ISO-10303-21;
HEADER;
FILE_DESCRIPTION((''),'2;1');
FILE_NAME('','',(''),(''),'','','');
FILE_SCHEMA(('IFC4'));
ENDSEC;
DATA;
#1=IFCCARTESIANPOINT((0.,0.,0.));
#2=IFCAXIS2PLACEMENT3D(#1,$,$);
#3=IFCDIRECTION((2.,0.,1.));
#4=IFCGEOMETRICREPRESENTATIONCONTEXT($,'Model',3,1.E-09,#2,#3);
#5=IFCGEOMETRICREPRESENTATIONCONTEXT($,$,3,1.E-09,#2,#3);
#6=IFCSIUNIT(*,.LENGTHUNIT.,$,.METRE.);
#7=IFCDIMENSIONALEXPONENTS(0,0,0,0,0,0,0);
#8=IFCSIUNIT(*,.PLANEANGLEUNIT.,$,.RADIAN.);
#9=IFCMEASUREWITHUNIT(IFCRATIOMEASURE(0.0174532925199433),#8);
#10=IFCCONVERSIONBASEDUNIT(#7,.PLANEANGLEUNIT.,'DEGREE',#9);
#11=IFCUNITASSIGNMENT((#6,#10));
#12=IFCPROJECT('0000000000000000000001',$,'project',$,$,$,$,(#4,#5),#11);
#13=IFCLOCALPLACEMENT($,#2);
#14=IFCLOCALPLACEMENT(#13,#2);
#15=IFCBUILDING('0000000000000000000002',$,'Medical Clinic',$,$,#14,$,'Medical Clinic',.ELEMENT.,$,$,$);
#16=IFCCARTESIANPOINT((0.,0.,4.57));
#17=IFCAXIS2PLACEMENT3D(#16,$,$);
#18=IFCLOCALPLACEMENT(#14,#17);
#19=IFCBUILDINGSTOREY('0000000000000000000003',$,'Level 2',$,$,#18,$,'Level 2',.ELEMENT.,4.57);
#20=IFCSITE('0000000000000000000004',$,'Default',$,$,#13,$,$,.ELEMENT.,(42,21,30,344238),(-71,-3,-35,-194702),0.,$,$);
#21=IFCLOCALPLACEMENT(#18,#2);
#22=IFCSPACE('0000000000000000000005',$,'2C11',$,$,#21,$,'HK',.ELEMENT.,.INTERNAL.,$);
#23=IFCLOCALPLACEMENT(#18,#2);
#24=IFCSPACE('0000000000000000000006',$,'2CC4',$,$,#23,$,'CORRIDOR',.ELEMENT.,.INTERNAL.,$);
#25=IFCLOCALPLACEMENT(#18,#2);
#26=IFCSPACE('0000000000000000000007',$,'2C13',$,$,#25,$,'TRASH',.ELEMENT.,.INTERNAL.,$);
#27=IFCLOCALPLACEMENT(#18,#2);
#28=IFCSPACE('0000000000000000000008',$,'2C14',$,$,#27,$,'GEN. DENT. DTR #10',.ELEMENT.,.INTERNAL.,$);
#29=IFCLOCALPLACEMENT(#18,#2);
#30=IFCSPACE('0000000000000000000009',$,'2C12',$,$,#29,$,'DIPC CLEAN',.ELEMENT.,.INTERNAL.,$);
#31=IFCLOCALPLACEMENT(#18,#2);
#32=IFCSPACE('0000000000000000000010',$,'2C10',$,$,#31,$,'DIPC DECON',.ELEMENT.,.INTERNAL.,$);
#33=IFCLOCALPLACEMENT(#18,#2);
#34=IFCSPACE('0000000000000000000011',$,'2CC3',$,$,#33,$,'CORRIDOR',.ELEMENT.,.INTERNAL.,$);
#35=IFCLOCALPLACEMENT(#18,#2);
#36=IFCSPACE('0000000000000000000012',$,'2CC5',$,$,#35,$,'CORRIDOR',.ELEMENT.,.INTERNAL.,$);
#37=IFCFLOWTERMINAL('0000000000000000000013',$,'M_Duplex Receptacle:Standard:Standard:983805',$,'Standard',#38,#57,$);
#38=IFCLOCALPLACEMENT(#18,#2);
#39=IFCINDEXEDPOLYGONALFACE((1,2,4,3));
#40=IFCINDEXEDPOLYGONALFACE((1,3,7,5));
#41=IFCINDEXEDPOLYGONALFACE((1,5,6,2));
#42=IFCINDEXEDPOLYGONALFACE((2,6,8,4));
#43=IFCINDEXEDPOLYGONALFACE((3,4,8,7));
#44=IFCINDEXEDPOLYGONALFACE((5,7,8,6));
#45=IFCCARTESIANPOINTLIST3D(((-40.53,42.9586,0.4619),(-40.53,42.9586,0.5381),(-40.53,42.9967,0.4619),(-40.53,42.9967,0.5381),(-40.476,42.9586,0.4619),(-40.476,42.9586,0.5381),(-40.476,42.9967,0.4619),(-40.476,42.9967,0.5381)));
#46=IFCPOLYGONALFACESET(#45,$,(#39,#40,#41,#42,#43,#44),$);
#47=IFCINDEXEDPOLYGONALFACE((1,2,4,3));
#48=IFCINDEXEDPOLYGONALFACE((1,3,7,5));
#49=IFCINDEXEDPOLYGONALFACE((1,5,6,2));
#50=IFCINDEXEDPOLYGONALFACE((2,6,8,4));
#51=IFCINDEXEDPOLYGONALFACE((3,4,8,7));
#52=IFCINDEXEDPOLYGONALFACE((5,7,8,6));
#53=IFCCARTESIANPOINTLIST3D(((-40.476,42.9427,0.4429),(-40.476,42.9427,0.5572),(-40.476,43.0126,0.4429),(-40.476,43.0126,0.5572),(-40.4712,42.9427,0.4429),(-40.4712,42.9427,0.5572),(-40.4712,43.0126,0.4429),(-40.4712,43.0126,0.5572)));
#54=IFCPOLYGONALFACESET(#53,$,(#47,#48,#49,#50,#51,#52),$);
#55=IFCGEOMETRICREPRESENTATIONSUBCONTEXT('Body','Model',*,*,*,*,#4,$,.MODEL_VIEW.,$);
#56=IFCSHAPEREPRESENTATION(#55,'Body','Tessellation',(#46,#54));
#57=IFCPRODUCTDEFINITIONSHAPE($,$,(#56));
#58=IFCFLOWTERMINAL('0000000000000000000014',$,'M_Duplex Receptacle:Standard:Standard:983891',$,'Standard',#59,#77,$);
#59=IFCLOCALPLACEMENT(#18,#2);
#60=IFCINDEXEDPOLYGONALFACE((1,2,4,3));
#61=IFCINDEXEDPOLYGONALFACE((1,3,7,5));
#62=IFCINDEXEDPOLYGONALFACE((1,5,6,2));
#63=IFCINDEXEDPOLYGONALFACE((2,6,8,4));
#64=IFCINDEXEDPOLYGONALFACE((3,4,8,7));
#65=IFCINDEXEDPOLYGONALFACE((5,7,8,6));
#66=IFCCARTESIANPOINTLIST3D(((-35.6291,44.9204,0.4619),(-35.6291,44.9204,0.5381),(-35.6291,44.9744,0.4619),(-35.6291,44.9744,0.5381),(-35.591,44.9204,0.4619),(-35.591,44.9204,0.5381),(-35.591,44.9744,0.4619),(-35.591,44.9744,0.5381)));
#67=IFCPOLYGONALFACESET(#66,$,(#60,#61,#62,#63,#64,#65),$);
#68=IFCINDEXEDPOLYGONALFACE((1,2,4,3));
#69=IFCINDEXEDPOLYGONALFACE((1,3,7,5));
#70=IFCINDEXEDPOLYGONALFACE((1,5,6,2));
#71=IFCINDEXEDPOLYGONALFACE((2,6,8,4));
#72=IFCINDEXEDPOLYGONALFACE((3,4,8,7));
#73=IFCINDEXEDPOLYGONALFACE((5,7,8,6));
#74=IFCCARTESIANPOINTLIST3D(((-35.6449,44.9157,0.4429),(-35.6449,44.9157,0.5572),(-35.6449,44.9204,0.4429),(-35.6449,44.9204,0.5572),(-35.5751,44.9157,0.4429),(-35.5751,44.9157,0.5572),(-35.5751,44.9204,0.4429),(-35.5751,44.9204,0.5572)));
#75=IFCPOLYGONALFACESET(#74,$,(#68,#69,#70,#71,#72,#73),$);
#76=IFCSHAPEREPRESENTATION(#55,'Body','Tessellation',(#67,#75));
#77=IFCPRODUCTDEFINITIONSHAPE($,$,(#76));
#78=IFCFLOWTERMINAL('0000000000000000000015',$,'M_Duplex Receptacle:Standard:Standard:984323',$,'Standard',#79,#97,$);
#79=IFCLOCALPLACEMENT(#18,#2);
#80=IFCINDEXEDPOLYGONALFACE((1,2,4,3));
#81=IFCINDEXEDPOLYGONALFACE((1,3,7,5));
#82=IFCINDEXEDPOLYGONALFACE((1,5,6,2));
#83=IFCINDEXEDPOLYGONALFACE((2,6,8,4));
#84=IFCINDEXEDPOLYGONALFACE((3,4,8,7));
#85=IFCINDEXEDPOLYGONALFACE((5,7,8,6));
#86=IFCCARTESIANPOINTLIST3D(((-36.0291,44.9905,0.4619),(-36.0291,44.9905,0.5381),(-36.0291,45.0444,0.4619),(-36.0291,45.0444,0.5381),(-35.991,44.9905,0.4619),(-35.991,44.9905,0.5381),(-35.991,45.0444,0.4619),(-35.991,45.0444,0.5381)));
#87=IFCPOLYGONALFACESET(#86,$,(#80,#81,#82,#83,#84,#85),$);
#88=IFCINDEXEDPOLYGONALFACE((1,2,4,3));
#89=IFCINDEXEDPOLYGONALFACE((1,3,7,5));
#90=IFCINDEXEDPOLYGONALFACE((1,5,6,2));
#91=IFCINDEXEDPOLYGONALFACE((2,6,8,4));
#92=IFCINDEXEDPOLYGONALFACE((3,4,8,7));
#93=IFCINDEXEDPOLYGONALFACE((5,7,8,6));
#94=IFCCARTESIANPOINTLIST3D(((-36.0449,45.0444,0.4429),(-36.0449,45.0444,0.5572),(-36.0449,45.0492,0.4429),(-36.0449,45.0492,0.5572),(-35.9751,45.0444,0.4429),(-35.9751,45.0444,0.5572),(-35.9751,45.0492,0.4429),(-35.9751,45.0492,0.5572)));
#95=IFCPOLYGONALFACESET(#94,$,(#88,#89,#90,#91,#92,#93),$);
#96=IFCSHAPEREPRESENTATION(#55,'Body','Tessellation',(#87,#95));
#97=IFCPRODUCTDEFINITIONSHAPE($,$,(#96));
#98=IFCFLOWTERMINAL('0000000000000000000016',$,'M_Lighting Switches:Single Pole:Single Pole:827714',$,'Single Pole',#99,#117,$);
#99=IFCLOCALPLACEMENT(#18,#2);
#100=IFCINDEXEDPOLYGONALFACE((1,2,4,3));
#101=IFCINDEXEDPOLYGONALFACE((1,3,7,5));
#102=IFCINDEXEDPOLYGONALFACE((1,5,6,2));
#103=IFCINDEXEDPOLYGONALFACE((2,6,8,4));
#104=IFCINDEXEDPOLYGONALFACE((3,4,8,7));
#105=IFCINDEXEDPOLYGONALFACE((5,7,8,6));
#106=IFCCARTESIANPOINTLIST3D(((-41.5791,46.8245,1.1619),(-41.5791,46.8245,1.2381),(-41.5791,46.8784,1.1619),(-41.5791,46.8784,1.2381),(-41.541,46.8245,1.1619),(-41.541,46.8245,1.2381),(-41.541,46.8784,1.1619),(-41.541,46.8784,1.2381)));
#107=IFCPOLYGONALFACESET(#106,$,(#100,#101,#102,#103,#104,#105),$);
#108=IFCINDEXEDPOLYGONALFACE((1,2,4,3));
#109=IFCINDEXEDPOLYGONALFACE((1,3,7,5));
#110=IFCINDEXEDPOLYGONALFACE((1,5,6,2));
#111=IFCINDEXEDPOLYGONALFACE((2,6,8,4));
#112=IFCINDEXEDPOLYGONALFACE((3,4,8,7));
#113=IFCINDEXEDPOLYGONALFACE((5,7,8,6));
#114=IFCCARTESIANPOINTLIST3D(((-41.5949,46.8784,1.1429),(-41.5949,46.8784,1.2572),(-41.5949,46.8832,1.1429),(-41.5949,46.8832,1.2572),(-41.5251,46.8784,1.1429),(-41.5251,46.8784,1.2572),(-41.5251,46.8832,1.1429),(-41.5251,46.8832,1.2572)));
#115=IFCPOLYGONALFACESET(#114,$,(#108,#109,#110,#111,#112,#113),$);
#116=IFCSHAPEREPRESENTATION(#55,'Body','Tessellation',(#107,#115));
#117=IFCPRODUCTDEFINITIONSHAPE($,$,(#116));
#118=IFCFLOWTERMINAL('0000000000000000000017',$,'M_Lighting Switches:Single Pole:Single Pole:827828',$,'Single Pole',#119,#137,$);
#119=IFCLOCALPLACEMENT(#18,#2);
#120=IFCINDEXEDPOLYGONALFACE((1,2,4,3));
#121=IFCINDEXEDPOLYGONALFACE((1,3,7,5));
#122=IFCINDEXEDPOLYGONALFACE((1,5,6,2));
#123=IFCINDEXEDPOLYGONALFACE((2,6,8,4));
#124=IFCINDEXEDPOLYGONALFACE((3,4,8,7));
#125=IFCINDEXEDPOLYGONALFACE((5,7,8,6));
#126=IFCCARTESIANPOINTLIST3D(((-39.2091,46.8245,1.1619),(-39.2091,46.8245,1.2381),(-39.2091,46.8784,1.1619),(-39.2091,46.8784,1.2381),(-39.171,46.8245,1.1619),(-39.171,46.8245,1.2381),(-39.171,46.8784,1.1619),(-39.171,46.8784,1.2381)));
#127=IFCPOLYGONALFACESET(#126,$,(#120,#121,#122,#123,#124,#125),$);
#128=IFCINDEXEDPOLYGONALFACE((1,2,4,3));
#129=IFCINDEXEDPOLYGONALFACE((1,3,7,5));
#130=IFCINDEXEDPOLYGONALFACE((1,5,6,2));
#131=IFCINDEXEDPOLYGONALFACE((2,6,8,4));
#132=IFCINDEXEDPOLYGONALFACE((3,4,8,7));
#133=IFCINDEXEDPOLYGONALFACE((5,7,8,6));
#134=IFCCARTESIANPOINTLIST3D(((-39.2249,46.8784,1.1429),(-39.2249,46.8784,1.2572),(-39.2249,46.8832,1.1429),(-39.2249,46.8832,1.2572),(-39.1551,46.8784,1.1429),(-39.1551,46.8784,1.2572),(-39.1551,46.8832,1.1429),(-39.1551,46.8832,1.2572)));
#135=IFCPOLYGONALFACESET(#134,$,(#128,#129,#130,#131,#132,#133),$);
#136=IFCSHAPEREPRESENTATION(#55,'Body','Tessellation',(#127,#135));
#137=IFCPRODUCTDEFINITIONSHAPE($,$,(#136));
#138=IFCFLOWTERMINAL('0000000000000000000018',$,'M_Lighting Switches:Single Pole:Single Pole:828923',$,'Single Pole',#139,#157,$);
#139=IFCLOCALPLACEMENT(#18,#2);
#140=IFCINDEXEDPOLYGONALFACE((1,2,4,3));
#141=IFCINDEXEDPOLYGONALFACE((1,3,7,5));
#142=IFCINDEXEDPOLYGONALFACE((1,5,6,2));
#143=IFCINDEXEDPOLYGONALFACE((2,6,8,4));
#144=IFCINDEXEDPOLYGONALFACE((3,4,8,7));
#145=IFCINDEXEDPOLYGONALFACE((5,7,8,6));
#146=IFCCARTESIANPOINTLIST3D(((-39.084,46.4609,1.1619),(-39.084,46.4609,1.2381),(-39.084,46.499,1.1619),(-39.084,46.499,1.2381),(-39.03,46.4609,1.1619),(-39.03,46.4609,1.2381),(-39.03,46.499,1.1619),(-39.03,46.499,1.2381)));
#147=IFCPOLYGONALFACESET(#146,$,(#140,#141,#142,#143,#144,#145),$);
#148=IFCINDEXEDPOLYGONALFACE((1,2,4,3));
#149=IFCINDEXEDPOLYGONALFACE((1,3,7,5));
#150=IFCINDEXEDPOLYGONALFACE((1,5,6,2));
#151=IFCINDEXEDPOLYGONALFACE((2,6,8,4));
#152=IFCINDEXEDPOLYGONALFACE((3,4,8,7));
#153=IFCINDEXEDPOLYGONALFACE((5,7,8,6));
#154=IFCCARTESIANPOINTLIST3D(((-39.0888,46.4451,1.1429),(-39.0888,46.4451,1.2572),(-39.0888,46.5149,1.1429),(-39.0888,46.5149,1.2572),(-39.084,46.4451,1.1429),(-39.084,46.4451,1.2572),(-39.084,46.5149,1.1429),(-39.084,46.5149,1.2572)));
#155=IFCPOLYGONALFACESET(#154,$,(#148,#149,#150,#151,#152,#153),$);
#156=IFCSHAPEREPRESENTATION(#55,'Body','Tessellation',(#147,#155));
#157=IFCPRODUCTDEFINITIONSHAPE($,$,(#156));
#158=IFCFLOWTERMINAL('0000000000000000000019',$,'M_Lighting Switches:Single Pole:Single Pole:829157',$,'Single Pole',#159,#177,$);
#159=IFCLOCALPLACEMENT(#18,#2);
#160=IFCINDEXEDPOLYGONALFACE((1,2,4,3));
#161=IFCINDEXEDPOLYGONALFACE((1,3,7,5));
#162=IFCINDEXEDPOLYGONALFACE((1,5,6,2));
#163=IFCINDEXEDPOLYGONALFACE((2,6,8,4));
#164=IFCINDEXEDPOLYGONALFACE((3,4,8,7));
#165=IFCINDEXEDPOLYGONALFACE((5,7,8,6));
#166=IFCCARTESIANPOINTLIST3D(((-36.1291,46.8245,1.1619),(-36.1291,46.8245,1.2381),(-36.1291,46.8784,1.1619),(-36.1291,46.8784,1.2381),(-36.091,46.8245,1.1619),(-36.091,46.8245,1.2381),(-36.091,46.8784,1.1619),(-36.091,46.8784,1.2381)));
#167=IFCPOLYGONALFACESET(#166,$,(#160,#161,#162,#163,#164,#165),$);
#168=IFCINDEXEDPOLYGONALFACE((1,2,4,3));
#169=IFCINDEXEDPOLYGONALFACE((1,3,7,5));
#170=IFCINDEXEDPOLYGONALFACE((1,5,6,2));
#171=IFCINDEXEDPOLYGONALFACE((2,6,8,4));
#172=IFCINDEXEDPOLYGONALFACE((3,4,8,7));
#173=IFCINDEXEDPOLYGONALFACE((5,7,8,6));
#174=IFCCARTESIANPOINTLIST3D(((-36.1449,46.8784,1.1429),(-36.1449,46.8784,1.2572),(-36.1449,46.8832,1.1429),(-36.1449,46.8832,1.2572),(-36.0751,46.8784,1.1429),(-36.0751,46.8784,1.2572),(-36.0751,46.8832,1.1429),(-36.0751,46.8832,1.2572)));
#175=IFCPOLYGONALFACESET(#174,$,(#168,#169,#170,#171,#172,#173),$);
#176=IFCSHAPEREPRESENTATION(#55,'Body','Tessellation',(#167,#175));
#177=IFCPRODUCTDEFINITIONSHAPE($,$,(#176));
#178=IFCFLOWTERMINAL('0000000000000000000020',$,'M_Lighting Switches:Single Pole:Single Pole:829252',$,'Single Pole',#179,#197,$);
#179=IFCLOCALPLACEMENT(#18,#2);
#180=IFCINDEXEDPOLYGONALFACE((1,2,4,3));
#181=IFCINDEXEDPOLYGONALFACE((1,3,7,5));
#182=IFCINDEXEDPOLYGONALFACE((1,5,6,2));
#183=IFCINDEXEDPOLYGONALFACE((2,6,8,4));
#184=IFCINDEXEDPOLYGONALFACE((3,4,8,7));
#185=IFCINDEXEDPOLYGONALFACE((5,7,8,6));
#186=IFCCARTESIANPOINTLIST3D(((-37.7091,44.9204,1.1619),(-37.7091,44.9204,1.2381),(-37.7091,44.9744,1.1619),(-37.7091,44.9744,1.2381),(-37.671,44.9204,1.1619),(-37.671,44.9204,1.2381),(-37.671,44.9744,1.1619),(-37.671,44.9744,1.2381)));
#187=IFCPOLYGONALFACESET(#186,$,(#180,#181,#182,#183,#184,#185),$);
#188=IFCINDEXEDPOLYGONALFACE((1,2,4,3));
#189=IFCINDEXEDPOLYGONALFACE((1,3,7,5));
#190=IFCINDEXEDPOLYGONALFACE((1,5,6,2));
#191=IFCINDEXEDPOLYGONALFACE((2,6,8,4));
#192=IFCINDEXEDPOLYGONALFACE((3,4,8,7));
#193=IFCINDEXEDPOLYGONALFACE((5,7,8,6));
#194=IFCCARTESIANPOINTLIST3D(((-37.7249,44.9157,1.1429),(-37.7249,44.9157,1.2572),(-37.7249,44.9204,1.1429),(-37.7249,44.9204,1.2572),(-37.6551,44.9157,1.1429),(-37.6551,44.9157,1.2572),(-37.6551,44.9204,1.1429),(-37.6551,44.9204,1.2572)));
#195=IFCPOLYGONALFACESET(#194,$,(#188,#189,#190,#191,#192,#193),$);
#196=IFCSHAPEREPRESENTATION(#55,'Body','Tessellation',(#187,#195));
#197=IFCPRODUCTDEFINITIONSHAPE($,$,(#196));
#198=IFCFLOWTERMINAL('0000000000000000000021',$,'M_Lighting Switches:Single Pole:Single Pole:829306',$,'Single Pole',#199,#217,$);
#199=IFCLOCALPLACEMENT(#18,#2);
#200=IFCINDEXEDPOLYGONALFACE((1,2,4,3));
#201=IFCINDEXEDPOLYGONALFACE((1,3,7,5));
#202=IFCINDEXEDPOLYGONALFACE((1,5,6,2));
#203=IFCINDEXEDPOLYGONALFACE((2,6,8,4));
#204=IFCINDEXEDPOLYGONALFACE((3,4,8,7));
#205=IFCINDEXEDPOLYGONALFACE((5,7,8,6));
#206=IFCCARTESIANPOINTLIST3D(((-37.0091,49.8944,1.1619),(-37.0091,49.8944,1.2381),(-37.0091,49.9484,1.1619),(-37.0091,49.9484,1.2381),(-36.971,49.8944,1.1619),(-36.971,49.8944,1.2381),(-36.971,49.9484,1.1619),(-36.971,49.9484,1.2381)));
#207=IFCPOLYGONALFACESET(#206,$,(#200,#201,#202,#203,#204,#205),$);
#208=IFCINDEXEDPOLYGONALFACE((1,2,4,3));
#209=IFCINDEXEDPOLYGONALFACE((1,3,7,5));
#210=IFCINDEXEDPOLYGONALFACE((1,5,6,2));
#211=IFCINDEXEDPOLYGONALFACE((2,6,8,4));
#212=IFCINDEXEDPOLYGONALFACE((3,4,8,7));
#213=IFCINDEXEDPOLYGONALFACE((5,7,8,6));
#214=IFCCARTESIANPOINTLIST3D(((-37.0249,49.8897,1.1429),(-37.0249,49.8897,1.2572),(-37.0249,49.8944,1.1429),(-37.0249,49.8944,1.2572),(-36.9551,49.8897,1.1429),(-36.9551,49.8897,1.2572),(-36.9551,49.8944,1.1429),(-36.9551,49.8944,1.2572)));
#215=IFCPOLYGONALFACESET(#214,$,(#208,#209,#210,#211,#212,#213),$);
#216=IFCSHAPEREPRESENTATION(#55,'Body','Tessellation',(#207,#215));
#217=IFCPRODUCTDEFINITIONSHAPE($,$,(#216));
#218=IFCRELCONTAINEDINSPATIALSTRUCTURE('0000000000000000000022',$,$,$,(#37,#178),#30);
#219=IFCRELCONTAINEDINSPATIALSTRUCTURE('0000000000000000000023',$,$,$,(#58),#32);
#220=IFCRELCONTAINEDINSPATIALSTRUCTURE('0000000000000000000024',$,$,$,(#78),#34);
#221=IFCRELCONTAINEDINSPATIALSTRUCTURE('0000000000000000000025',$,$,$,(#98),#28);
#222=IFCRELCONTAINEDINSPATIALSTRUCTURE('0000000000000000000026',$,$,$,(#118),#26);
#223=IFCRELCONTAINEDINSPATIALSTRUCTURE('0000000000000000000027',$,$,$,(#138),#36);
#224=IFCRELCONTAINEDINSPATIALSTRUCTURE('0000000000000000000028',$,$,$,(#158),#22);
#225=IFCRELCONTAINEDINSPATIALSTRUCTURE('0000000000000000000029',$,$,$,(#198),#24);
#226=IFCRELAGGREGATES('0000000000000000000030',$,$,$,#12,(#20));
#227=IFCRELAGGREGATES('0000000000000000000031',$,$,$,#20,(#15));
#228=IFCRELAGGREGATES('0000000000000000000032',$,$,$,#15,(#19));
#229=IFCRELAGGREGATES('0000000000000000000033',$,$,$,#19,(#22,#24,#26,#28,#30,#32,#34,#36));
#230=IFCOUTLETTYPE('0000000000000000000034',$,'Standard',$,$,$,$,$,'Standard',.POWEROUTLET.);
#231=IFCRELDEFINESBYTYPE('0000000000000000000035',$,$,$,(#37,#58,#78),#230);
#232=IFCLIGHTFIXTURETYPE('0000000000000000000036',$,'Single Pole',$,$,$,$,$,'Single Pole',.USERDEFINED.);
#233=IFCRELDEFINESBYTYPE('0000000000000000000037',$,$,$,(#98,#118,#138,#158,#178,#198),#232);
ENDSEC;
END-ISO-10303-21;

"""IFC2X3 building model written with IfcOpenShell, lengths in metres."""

from ifc_helpers import new_model, entity, si_unit, converted_unit, direction, frame, frame_2d, origin, origin_2d_with_axis, place, context, subcontext, project, spatial, rectangle, extrude, source, transform, mapped, type_object, type_shapes, element, save


model = new_model("IFC2X3")

# Units and contexts
model_context = context("Model", 3, precision=1e-09, world=origin(), true_north=direction((2.0, 0.0, 1.0)))
context_of_model = context(None, 3, precision=1e-09, world=origin(), true_north=direction((2.0, 0.0, 1.0)))
body_context = subcontext(model_context, "Body", "Model", "MODEL_VIEW")
ifc_project = project(units=[si_unit("LENGTHUNIT", "METRE"), converted_unit("PLANEANGLEUNIT", "DEGREE", entity("IfcRatioMeasure", 0.0174532925199433), si_unit("PLANEANGLEUNIT", "RADIAN"), dimensions=[0, 0, 0, 0, 0, 0, 0])], contexts=[model_context, context_of_model])

# Site, building, storey
site_placement = place(None, origin())
site = spatial("IfcSite", under=ifc_project, at=site_placement, Name="Default", CompositionType="ELEMENT", RefLatitude=(42, 21, 30, 344238), RefLongitude=(-71, -3, -35, -194702), RefElevation=0.0)
building_placement = place(site_placement, origin())
building = spatial("IfcBuilding", under=site, at=building_placement, Name="Medical Clinic", LongName="Medical Clinic", CompositionType="ELEMENT")
storey_placement = place(building_placement, frame((0.0, 0.0, 4.57)))
storey = spatial("IfcBuildingStorey", under=building, at=storey_placement, Name="Level 2", LongName="Level 2", CompositionType="ELEMENT", Elevation=4.57)

# Shared definitions
outlet_type = type_object("IfcOutletType", Name="Standard", ElementType="Standard", PredefinedType="POWEROUTLET")
shared_shape_1 = source(origin(), body_context, "Body", "SweptSolid", [
    extrude(rectangle(XDim=0.0381, YDim=0.0762, at=origin_2d_with_axis()), frame((0.0, 0.0, -0.054), z_axis=(0.0, 0.0, 1.0), x_axis=(-1.0, 0.0, 0.0)), (0.0, 0.0, 1.0), 0.054),
    extrude(rectangle(XDim=0.0698, YDim=0.1143, at=frame_2d((0.0, 0.0), x_axis=(1.0, 0.0))), frame((0.0, 0.0, 0.0), z_axis=(0.0, 0.0, 1.0), x_axis=(-1.0, 0.0, 0.0)), (0.0, 0.0, 1.0), 0.0048),
])
type_shapes(outlet_type, [shared_shape_1])

# Shared definitions
space_1_placement = place(storey_placement, origin())
space_1 = spatial("IfcSpace", under=storey, at=space_1_placement, Name="2C11", LongName="HK", CompositionType="ELEMENT", InteriorOrExteriorSpace="INTERNAL")

# Shared definitions
space_2_placement = place(storey_placement, origin())
space_2 = spatial("IfcSpace", under=storey, at=space_2_placement, Name="2CC4", LongName="CORRIDOR", CompositionType="ELEMENT", InteriorOrExteriorSpace="INTERNAL")

# Shared definitions
space_3_placement = place(storey_placement, origin())
space_3 = spatial("IfcSpace", under=storey, at=space_3_placement, Name="2C13", LongName="TRASH", CompositionType="ELEMENT", InteriorOrExteriorSpace="INTERNAL")

# Shared definitions
space_4_placement = place(storey_placement, origin())
space_4 = spatial("IfcSpace", under=storey, at=space_4_placement, Name="2C14", LongName="GEN. DENT. DTR #10", CompositionType="ELEMENT", InteriorOrExteriorSpace="INTERNAL")

# Shared definitions
space_5_placement = place(storey_placement, origin())
space_5 = spatial("IfcSpace", under=storey, at=space_5_placement, Name="2C12", LongName="DIPC CLEAN", CompositionType="ELEMENT", InteriorOrExteriorSpace="INTERNAL")

# Flow terminal
flow_terminal_1_placement = place(space_5_placement, frame((-40.476, 42.9776, 0.5), z_axis=(1.0, 0.0, 0.0), x_axis=(0.0, 1.0, 0.0)))
element("IfcFlowTerminal", 1, at=flow_terminal_1_placement, inside=space_5, type_object=outlet_type, Name="M_Duplex Receptacle:Standard:Standard:983805", ObjectType="Standard", context=body_context, shape_type="MappedRepresentation", body=[
    mapped(shared_shape_1, transform((0.0, 0.0, 0.0), scale=1.0)),
])

# Shared definitions
space_6_placement = place(storey_placement, origin())
space_6 = spatial("IfcSpace", under=storey, at=space_6_placement, Name="2C10", LongName="DIPC DECON", CompositionType="ELEMENT", InteriorOrExteriorSpace="INTERNAL")

# Flow terminal
flow_terminal_2_placement = place(space_6_placement, frame((-35.61, 44.9204, 0.5), z_axis=(0.0, -1.0, 0.0), x_axis=(1.0, 0.0, 0.0)))
element("IfcFlowTerminal", 2, at=flow_terminal_2_placement, inside=space_6, type_object=outlet_type, Name="M_Duplex Receptacle:Standard:Standard:983891", ObjectType="Standard", context=body_context, shape_type="MappedRepresentation", body=[
    mapped(shared_shape_1, transform((0.0, 0.0, 0.0), scale=1.0)),
])

# Shared definitions
space_7_placement = place(storey_placement, origin())
space_7 = spatial("IfcSpace", under=storey, at=space_7_placement, Name="2CC3", LongName="CORRIDOR", CompositionType="ELEMENT", InteriorOrExteriorSpace="INTERNAL")

# Flow terminals
flow_terminal_3_placement = place(space_7_placement, frame((-36.01, 45.0444, 0.5), z_axis=(0.0, 1.0, 0.0), x_axis=(-1.0, 0.0, 0.0)))
element("IfcFlowTerminal", 3, at=flow_terminal_3_placement, inside=space_7, type_object=outlet_type, Name="M_Duplex Receptacle:Standard:Standard:984323", ObjectType="Standard", context=body_context, shape_type="MappedRepresentation", body=[
    mapped(shared_shape_1, transform((0.0, 0.0, 0.0), scale=1.0)),
])
light_fixture_type_1 = type_object("IfcLightFixtureType", Name="Single Pole", ElementType="Single Pole", PredefinedType="USERDEFINED")
shared_shape_2 = source(origin(), body_context, "Body", "SweptSolid", [
    extrude(rectangle(XDim=0.0381, YDim=0.0762, at=origin_2d_with_axis()), frame((0.0, 0.0, -0.054), z_axis=(0.0, 0.0, 1.0), x_axis=(-1.0, 0.0, 0.0)), (0.0, 0.0, 1.0), 0.054),
    extrude(rectangle(XDim=0.0698, YDim=0.1143, at=frame_2d((0.0, 0.0), x_axis=(1.0, 0.0))), frame((0.0, 0.0, 0.0), z_axis=(0.0, 0.0, 1.0), x_axis=(-1.0, 0.0, 0.0)), (0.0, 0.0, 1.0), 0.0048),
])
type_shapes(light_fixture_type_1, [shared_shape_2])
flow_terminal_4_placement = place(space_4_placement, frame((-41.56, 46.8784, 1.2), z_axis=(0.0, 1.0, 0.0), x_axis=(-1.0, 0.0, 0.0)))
element("IfcFlowTerminal", 4, at=flow_terminal_4_placement, inside=space_4, type_object=light_fixture_type_1, Name="M_Lighting Switches:Single Pole:Single Pole:827714", ObjectType="Single Pole", context=body_context, shape_type="MappedRepresentation", body=[
    mapped(shared_shape_2, transform((0.0, 0.0, 0.0), scale=1.0)),
])
flow_terminal_5_placement = place(space_3_placement, frame((-39.19, 46.8784, 1.2), z_axis=(0.0, 1.0, 0.0), x_axis=(-1.0, 0.0, 0.0)))
element("IfcFlowTerminal", 5, at=flow_terminal_5_placement, inside=space_3, type_object=light_fixture_type_1, Name="M_Lighting Switches:Single Pole:Single Pole:827828", ObjectType="Single Pole", context=body_context, shape_type="MappedRepresentation", body=[
    mapped(shared_shape_2, transform((0.0, 0.0, 0.0), scale=1.0)),
])

# Shared definitions
space_8_placement = place(storey_placement, origin())
space_8 = spatial("IfcSpace", under=storey, at=space_8_placement, Name="2CC5", LongName="CORRIDOR", CompositionType="ELEMENT", InteriorOrExteriorSpace="INTERNAL")

# Flow terminals
flow_terminal_6_placement = place(space_8_placement, frame((-39.084, 46.48, 1.2), z_axis=(-1.0, 0.0, 0.0), x_axis=(0.0, -1.0, 0.0)))
element("IfcFlowTerminal", 6, at=flow_terminal_6_placement, inside=space_8, type_object=light_fixture_type_1, Name="M_Lighting Switches:Single Pole:Single Pole:828923", ObjectType="Single Pole", context=body_context, shape_type="MappedRepresentation", body=[
    mapped(shared_shape_2, transform((0.0, 0.0, 0.0), scale=1.0)),
])
flow_terminal_7_placement = place(space_1_placement, frame((-36.11, 46.8784, 1.2), z_axis=(0.0, 1.0, 0.0), x_axis=(-1.0, 0.0, 0.0)))
element("IfcFlowTerminal", 7, at=flow_terminal_7_placement, inside=space_1, type_object=light_fixture_type_1, Name="M_Lighting Switches:Single Pole:Single Pole:829157", ObjectType="Single Pole", context=body_context, shape_type="MappedRepresentation", body=[
    mapped(shared_shape_2, transform((0.0, 0.0, 0.0), scale=1.0)),
])
flow_terminal_8_placement = place(space_5_placement, frame((-37.69, 44.9204, 1.2), z_axis=(0.0, -1.0, 0.0), x_axis=(1.0, 0.0, 0.0)))
element("IfcFlowTerminal", 8, at=flow_terminal_8_placement, inside=space_5, type_object=light_fixture_type_1, Name="M_Lighting Switches:Single Pole:Single Pole:829252", ObjectType="Single Pole", context=body_context, shape_type="MappedRepresentation", body=[
    mapped(shared_shape_2, transform((0.0, 0.0, 0.0), scale=1.0)),
])
flow_terminal_9_placement = place(space_2_placement, frame((-36.99, 49.8944, 1.2), z_axis=(0.0, -1.0, 0.0), x_axis=(1.0, 0.0, 0.0)))
element("IfcFlowTerminal", 9, at=flow_terminal_9_placement, inside=space_2, type_object=light_fixture_type_1, Name="M_Lighting Switches:Single Pole:Single Pole:829306", ObjectType="Single Pole", context=body_context, shape_type="MappedRepresentation", body=[
    mapped(shared_shape_2, transform((0.0, 0.0, 0.0), scale=1.0)),
])

save(model, "model.ifc")
